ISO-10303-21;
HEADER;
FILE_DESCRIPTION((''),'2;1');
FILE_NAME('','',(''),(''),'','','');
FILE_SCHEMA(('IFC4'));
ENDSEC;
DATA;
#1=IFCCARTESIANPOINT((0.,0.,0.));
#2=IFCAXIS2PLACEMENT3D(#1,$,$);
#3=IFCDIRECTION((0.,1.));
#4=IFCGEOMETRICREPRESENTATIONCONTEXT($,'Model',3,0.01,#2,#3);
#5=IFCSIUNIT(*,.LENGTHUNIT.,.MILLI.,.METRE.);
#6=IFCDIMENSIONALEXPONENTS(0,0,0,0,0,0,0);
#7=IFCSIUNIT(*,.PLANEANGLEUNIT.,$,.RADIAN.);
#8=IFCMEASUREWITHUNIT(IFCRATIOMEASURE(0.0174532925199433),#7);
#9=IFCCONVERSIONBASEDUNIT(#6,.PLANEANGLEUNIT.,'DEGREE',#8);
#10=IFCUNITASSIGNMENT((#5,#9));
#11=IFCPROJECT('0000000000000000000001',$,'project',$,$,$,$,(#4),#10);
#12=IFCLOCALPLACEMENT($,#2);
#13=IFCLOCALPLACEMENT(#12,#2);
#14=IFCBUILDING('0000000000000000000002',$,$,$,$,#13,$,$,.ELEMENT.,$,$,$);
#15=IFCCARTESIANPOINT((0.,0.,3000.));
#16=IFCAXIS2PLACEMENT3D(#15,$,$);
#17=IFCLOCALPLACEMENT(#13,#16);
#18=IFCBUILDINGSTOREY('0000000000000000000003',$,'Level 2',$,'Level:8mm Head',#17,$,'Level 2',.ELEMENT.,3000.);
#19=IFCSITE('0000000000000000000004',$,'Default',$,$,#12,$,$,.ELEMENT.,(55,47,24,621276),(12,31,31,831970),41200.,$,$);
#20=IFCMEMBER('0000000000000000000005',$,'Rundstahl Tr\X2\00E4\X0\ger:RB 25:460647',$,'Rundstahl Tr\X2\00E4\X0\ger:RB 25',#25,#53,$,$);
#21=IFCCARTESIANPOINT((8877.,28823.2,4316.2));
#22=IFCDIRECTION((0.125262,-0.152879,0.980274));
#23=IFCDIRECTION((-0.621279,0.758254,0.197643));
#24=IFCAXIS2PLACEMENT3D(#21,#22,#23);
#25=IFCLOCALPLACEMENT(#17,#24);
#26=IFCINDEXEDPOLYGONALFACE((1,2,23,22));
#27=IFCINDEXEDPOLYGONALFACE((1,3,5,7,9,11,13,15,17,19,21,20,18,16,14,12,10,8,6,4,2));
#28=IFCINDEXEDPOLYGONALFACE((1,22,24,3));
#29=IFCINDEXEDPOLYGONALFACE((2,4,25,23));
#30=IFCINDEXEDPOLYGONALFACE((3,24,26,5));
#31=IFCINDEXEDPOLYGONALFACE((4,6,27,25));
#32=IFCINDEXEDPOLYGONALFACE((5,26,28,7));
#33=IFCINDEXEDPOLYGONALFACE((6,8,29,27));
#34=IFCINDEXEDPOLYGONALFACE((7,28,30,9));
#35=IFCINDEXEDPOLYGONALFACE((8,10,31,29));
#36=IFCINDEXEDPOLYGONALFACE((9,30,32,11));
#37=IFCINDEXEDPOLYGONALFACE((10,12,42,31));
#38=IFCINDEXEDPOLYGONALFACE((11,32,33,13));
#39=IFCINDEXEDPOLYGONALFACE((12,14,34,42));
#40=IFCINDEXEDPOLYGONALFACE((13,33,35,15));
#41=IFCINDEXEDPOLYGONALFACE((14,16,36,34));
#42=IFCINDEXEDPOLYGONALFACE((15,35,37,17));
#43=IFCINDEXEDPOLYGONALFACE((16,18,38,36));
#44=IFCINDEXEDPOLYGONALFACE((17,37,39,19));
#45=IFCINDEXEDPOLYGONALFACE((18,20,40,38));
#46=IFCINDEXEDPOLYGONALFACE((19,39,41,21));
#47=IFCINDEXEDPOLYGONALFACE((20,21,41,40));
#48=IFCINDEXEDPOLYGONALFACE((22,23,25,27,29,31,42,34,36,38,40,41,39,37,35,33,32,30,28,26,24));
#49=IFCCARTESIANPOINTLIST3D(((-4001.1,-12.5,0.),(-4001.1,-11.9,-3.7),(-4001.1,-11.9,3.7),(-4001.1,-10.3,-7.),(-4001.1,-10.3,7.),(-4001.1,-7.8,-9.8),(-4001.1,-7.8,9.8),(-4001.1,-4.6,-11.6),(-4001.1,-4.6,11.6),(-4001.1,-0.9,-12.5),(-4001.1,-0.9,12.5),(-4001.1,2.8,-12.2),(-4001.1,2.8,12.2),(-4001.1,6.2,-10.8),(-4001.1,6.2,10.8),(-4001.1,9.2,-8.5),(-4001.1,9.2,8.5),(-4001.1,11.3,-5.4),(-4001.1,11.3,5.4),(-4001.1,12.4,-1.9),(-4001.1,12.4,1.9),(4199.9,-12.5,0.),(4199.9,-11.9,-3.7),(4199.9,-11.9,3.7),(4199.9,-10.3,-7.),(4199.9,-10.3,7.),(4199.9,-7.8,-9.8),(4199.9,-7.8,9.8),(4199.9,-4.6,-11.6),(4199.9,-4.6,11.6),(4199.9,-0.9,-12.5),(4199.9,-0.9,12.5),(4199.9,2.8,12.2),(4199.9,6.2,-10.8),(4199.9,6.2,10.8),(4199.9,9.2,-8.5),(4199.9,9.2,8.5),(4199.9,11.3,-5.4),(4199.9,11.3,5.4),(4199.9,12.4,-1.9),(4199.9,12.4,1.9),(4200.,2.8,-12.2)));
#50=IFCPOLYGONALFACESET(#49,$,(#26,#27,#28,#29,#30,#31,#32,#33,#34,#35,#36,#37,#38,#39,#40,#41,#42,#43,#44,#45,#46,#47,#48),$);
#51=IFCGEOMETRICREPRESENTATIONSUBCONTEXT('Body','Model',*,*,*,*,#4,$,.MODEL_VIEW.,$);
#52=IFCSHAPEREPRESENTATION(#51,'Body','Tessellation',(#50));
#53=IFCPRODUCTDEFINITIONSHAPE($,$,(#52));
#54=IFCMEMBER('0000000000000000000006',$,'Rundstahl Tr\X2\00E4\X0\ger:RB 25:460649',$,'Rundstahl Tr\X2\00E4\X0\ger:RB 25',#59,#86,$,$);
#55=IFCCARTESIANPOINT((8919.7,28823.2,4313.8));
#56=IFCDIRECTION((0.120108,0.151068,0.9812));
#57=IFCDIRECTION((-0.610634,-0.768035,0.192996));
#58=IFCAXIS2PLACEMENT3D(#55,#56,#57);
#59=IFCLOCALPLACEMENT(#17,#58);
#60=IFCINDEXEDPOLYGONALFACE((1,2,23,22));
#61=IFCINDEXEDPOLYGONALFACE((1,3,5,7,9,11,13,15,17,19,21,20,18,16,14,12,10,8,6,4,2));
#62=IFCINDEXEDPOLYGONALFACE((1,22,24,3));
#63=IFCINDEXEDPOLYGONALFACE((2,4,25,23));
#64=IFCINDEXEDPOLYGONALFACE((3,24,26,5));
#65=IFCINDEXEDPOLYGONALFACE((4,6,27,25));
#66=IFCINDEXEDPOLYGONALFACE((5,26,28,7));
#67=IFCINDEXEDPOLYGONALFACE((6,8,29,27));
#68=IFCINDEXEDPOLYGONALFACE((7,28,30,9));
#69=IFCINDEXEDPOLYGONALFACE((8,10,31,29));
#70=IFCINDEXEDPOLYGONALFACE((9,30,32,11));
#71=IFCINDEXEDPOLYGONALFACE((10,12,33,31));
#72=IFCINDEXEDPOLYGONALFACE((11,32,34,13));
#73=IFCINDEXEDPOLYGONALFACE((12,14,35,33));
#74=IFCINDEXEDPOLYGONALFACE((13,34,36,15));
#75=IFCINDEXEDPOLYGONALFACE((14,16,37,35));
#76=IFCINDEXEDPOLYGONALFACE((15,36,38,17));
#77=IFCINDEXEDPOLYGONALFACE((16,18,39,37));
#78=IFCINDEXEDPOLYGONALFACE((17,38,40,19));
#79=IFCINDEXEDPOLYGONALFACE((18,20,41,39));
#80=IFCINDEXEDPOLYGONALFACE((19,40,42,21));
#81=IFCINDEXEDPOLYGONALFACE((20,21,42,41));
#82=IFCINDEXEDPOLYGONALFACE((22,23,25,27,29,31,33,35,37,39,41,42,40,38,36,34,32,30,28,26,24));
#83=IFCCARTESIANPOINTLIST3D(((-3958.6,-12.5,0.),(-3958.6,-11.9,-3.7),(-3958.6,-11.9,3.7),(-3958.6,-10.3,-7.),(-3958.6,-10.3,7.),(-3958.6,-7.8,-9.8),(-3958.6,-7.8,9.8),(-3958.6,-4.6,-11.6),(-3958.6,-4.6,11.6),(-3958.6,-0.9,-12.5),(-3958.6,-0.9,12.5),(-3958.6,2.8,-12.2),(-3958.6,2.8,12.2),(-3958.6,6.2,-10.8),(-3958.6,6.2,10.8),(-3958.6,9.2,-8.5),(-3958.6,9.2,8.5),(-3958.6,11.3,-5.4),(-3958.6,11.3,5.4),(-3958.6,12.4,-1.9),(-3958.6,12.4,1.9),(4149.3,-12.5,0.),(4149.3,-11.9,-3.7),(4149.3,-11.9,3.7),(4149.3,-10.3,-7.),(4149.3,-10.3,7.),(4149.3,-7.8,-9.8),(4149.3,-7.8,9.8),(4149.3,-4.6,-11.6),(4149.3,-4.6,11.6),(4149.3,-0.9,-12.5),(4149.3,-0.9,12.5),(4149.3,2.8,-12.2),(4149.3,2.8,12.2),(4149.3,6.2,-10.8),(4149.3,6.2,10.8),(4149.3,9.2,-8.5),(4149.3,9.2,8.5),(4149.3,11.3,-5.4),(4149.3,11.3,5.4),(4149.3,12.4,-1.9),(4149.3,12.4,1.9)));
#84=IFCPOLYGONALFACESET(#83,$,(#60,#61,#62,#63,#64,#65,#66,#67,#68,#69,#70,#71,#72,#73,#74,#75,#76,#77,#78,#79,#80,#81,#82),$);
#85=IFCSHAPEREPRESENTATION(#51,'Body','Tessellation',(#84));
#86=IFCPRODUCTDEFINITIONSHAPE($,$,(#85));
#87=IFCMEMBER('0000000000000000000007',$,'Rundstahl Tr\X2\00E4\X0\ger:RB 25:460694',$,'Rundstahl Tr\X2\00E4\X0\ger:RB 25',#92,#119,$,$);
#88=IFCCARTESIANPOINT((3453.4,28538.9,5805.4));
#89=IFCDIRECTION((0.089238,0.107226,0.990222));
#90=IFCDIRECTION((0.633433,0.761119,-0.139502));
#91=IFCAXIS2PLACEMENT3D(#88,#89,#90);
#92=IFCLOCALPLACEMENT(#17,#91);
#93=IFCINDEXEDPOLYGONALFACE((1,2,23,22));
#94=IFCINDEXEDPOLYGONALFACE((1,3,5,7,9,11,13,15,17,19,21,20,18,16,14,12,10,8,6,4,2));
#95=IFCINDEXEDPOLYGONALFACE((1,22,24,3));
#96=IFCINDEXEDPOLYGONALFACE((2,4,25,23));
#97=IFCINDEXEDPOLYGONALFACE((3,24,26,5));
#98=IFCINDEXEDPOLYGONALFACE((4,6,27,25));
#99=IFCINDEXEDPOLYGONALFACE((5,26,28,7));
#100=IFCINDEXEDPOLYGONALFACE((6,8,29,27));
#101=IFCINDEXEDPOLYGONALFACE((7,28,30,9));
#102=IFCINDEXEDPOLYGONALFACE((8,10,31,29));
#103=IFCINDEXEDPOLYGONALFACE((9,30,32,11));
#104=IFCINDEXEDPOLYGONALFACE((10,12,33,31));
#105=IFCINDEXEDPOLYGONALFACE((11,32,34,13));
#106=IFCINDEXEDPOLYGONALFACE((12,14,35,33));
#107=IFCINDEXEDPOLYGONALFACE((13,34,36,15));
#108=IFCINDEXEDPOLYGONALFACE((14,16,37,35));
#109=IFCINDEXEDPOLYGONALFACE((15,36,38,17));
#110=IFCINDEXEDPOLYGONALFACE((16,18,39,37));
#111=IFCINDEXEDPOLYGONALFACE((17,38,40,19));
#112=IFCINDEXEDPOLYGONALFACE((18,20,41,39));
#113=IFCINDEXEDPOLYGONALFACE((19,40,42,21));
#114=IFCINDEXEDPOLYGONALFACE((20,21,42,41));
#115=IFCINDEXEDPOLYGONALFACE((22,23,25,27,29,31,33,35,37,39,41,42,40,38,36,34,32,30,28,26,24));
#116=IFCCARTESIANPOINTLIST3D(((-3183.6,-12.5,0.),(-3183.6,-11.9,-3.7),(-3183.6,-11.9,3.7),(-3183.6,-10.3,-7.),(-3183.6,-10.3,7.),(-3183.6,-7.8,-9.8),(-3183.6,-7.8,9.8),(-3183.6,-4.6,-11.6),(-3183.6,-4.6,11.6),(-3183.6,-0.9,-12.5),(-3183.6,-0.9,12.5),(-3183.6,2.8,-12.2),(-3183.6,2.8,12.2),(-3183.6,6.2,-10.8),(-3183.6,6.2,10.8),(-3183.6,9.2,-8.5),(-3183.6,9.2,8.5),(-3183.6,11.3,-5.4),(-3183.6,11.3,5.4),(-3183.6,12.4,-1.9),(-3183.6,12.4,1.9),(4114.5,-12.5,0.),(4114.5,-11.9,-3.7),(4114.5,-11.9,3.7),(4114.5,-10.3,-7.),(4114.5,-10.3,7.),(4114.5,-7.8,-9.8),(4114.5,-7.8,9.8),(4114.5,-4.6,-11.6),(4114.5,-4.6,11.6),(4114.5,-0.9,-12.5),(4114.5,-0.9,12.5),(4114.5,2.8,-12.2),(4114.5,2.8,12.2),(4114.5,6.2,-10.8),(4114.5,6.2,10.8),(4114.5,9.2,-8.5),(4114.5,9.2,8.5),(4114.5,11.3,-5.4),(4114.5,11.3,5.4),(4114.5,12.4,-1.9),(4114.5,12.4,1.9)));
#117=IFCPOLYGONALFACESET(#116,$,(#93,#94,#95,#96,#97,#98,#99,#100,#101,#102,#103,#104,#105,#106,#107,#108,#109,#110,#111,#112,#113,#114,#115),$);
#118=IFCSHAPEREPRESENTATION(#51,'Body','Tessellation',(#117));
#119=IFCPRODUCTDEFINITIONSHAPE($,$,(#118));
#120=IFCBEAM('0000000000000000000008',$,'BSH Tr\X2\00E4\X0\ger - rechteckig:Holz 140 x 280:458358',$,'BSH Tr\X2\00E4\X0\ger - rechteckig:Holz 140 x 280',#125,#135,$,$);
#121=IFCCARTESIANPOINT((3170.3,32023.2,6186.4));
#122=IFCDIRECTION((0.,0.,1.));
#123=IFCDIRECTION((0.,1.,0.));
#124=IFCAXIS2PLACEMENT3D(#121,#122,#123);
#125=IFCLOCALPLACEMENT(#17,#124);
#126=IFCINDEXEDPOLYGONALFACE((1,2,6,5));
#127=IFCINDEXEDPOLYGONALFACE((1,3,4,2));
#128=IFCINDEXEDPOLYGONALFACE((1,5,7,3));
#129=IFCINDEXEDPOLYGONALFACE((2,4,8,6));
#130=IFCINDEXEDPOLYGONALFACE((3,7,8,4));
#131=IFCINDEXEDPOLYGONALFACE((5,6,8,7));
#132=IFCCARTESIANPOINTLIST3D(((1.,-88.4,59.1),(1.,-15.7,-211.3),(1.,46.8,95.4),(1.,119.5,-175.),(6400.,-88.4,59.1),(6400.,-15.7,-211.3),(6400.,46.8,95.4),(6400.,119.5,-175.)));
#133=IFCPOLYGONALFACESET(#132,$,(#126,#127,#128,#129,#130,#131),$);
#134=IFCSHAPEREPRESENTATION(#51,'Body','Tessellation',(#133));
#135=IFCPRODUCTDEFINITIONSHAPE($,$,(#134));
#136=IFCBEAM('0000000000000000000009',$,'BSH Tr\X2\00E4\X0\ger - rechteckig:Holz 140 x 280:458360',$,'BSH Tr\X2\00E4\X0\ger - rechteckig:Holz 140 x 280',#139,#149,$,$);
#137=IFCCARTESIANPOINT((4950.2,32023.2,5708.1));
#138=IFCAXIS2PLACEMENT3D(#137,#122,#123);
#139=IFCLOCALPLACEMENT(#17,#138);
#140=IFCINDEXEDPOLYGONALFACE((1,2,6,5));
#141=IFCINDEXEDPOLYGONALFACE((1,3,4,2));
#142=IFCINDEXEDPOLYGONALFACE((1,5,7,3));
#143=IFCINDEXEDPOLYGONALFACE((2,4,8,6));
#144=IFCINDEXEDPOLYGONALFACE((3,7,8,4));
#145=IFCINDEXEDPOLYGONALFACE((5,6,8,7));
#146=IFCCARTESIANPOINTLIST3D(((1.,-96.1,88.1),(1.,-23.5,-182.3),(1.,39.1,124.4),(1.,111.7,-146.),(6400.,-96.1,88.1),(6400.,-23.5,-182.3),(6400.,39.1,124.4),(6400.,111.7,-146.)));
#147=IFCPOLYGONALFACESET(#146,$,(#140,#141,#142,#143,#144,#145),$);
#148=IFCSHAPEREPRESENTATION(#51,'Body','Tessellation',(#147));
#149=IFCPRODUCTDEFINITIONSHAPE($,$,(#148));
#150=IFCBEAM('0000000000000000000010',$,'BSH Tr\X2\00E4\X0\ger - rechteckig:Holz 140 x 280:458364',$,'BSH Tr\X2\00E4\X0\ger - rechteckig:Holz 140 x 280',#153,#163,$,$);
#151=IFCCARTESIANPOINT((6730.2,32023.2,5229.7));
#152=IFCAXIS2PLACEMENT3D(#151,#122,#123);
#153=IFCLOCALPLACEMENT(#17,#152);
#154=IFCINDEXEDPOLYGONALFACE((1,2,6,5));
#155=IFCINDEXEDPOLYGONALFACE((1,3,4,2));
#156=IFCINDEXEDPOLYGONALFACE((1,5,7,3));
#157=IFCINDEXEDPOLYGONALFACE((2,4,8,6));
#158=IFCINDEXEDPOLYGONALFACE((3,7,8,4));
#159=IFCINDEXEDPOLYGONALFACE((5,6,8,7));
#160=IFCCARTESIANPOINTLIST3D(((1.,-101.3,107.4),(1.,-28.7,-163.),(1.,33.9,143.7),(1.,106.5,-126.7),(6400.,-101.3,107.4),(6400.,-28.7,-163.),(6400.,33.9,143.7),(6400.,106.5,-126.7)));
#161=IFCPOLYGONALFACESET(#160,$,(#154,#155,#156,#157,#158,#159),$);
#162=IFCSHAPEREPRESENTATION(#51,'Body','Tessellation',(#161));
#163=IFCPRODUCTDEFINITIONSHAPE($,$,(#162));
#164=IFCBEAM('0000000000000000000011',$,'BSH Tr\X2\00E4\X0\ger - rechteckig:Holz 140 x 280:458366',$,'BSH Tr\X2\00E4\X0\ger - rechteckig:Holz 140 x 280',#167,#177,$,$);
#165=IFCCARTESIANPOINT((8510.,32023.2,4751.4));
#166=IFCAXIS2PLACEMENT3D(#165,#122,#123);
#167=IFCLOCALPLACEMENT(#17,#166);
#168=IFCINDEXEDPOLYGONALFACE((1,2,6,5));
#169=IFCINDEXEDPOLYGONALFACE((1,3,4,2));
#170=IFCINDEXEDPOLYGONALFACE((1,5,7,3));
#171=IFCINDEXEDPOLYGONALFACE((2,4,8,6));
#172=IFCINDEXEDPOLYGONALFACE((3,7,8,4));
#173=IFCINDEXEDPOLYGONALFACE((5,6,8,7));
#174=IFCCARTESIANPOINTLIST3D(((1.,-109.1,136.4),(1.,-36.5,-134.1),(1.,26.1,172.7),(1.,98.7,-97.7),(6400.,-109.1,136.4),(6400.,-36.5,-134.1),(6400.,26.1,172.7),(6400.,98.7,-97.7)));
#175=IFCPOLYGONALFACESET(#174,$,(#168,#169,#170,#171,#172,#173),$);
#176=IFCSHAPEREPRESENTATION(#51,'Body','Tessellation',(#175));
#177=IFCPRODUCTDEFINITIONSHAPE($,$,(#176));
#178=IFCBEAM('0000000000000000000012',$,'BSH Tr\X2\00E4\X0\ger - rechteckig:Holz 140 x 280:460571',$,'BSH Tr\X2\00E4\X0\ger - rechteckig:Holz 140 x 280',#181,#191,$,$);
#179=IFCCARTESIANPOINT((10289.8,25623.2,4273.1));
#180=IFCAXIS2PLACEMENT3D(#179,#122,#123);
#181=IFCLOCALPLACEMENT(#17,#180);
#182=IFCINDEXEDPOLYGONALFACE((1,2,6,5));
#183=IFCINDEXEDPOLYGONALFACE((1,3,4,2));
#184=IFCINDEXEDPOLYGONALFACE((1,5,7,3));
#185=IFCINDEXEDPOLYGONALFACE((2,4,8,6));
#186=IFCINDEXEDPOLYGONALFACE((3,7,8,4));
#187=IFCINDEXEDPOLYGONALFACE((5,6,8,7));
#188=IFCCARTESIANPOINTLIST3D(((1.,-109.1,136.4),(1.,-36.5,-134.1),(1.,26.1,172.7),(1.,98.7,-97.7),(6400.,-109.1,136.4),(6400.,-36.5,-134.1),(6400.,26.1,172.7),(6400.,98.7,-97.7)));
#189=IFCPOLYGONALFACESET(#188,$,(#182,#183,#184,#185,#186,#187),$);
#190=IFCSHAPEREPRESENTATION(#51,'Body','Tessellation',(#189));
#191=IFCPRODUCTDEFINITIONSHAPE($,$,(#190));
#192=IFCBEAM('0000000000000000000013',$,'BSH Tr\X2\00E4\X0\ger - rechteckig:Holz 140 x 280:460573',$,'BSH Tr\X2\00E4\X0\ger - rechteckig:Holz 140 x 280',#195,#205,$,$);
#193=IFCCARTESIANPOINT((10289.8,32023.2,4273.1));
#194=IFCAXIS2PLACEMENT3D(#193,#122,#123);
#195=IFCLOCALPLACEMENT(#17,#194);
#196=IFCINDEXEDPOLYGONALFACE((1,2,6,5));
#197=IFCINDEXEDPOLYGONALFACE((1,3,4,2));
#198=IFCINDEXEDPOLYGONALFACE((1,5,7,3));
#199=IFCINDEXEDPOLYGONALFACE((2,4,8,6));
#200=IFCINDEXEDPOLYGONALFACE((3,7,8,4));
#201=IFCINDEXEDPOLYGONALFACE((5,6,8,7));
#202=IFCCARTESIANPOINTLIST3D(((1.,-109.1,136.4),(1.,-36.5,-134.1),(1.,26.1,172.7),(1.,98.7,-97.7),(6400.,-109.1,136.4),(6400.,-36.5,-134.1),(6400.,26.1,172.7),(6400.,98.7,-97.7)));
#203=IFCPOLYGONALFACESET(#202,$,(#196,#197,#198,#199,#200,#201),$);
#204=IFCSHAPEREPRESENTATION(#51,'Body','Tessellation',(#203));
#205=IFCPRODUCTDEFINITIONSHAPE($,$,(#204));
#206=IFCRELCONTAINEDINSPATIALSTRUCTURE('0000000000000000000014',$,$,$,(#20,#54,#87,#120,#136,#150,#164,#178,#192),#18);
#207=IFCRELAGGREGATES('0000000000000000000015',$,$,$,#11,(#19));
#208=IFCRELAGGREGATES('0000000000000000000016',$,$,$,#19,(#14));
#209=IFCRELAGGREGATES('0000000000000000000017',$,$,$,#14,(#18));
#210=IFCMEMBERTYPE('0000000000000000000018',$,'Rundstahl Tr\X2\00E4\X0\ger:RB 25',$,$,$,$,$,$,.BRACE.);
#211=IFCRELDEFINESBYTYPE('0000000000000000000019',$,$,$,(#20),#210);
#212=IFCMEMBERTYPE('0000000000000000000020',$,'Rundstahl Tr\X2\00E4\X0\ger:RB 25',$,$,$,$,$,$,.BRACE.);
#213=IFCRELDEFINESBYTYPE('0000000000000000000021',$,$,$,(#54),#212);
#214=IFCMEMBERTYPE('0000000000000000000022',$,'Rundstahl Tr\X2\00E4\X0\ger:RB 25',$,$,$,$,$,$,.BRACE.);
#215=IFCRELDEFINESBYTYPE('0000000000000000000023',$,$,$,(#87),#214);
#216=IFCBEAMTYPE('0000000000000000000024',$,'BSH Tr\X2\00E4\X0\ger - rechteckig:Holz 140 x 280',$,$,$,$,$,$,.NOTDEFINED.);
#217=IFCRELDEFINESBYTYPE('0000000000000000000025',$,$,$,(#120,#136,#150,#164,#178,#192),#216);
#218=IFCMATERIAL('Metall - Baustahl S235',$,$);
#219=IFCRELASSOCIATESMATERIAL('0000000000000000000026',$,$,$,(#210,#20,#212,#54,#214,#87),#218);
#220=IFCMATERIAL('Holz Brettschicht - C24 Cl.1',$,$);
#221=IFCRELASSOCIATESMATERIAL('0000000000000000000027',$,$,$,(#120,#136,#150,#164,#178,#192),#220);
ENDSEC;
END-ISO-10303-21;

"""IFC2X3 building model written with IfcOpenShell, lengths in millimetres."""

from ifc_helpers import new_model, entity, si_unit, converted_unit, direction, frame, frame_2d, origin, place, context, subcontext, project, spatial, rectangle, circle, extrude, source, transform, mapped, material, type_object, type_shapes, element, save


model = new_model("IFC2X3")

# Units and contexts
model_context = context("Model", 3, precision=0.01, world=origin(), true_north=direction((0.0, 1.0)))
body_context = subcontext(model_context, "Body", "Model", "MODEL_VIEW")
ifc_project = project(units=[si_unit("LENGTHUNIT", "METRE", prefix="MILLI"), converted_unit("PLANEANGLEUNIT", "DEGREE", entity("IfcRatioMeasure", 0.0174532925199433), si_unit("PLANEANGLEUNIT", "RADIAN"), dimensions=[0, 0, 0, 0, 0, 0, 0])], contexts=[model_context])

# Site, building, storey
site_placement = place(None, origin())
site = spatial("IfcSite", under=ifc_project, at=site_placement, Name="Default", CompositionType="ELEMENT", RefLatitude=(55, 47, 24, 621276), RefLongitude=(12, 31, 31, 831970), RefElevation=41200.0)
building_placement = place(site_placement, origin())
building = spatial("IfcBuilding", under=site, at=building_placement, CompositionType="ELEMENT")
storey_placement = place(building_placement, frame((0.0, 0.0, 3000.0)))
storey = spatial("IfcBuildingStorey", under=building, at=storey_placement, Name="Level 2", ObjectType="Level:8mm Head", LongName="Level 2", CompositionType="ELEMENT", Elevation=3000.0)

# Members
ifc_material_1 = material(Name="Metall - Baustahl S235")
member_type_1 = type_object("IfcMemberType", Name="Rundstahl Träger:RB 25", PredefinedType="BRACE", material=ifc_material_1)
shared_shape_1 = source(origin(), body_context, "Body", "SweptSolid", [
    extrude(circle(Radius=12.5, at=frame_2d((0.0, 0.0), x_axis=(1.0, 0.0))), frame((-4001.2, 0.0, 0.0), z_axis=(1.0, 0.0, 0.0), x_axis=(0.0, -1.0, 0.0)), (0.0, 0.0, 1.0), 8201.1),
])
type_shapes(member_type_1, [shared_shape_1])
member_1_placement = place(storey_placement, frame((8877.0, 28823.2, 4316.2), z_axis=(0.125262, -0.152879, 0.980274), x_axis=(-0.621279, 0.758254, 0.197643)))
element("IfcMember", 1, at=member_1_placement, inside=storey, type_object=member_type_1, material=ifc_material_1, Name="Rundstahl Träger:RB 25:460647", ObjectType="Rundstahl Träger:RB 25", context=body_context, shape_type="MappedRepresentation", body=[
    mapped(shared_shape_1, transform((0.0, 0.0, 0.0), scale=1.0)),
])
member_type_2 = type_object("IfcMemberType", Name="Rundstahl Träger:RB 25", PredefinedType="BRACE", material=ifc_material_1)
shared_shape_2 = source(origin(), body_context, "Body", "SweptSolid", [
    extrude(circle(Radius=12.5, at=frame_2d((0.0, 0.0), x_axis=(1.0, 0.0))), frame((-3958.6, 0.0, 0.0), z_axis=(1.0, 0.0, 0.0), x_axis=(0.0, -1.0, 0.0)), (0.0, 0.0, 1.0), 8107.9),
])
type_shapes(member_type_2, [shared_shape_2])
member_2_placement = place(storey_placement, frame((8919.7, 28823.2, 4313.8), z_axis=(0.120108, 0.151068, 0.9812), x_axis=(-0.610634, -0.768035, 0.192996)))
element("IfcMember", 2, at=member_2_placement, inside=storey, type_object=member_type_2, material=ifc_material_1, Name="Rundstahl Träger:RB 25:460649", ObjectType="Rundstahl Träger:RB 25", context=body_context, shape_type="MappedRepresentation", body=[
    mapped(shared_shape_2, transform((0.0, 0.0, 0.0), scale=1.0)),
])
member_type_3 = type_object("IfcMemberType", Name="Rundstahl Träger:RB 25", PredefinedType="BRACE", material=ifc_material_1)
shared_shape_3 = source(origin(), body_context, "Body", "SweptSolid", [
    extrude(circle(Radius=12.5, at=frame_2d((0.0, 0.0), x_axis=(1.0, 0.0))), frame((-3183.7, 0.0, 0.0), z_axis=(1.0, 0.0, 0.0), x_axis=(0.0, -1.0, 0.0)), (0.0, 0.0, 1.0), 7298.2),
])
type_shapes(member_type_3, [shared_shape_3])
member_3_placement = place(storey_placement, frame((3453.4, 28538.9, 5805.4), z_axis=(0.089238, 0.107226, 0.990222), x_axis=(0.633433, 0.761119, -0.139502)))
element("IfcMember", 3, at=member_3_placement, inside=storey, type_object=member_type_3, material=ifc_material_1, Name="Rundstahl Träger:RB 25:460694", ObjectType="Rundstahl Träger:RB 25", context=body_context, shape_type="MappedRepresentation", body=[
    mapped(shared_shape_3, transform((0.0, 0.0, 0.0), scale=1.0)),
])

# Beams
ifc_material_2 = material(Name="Holz Brettschicht - C24 Cl.1")
beam_type_1 = type_object("IfcBeamType", Name="BSH Träger - rechteckig:Holz 140 x 280", PredefinedType="NOTDEFINED")
beam_1_placement = place(storey_placement, frame((3170.3, 32023.2, 6186.4), z_axis=(0.0, 0.0, 1.0), x_axis=(0.0, 1.0, 0.0)))
element("IfcBeam", 4, at=beam_1_placement, inside=storey, type_object=beam_type_1, material=ifc_material_2, Name="BSH Träger - rechteckig:Holz 140 x 280:458358", ObjectType="BSH Träger - rechteckig:Holz 140 x 280", context=body_context, shape_type="SweptSolid", body=[
    extrude(rectangle(XDim=280.0, YDim=140.0, at=frame_2d((0.0, 0.0), x_axis=(1.0, 0.0))), frame((1.0, 15.6, -57.9), z_axis=(1.0, 0.0, 0.0), x_axis=(0.0, -0.259528, 0.965735)), (0.0, 0.0, 1.0), 6399.0),
])
beam_2_placement = place(storey_placement, frame((4950.2, 32023.2, 5708.1), z_axis=(0.0, 0.0, 1.0), x_axis=(0.0, 1.0, 0.0)))
element("IfcBeam", 5, at=beam_2_placement, inside=storey, type_object=beam_type_1, material=ifc_material_2, Name="BSH Träger - rechteckig:Holz 140 x 280:458360", ObjectType="BSH Träger - rechteckig:Holz 140 x 280", context=body_context, shape_type="SweptSolid", body=[
    extrude(rectangle(XDim=280.0, YDim=140.0, at=frame_2d((0.0, 0.0), x_axis=(1.0, 0.0))), frame((1.0, 7.8, -29.0), z_axis=(1.0, 0.0, 0.0), x_axis=(0.0, -0.259528, 0.965735)), (0.0, 0.0, 1.0), 6399.0),
])
beam_3_placement = place(storey_placement, frame((6730.2, 32023.2, 5229.7), z_axis=(0.0, 0.0, 1.0), x_axis=(0.0, 1.0, 0.0)))
element("IfcBeam", 6, at=beam_3_placement, inside=storey, type_object=beam_type_1, material=ifc_material_2, Name="BSH Träger - rechteckig:Holz 140 x 280:458364", ObjectType="BSH Träger - rechteckig:Holz 140 x 280", context=body_context, shape_type="SweptSolid", body=[
    extrude(rectangle(XDim=280.0, YDim=140.0, at=frame_2d((0.0, 0.0), x_axis=(1.0, 0.0))), frame((1.0, 2.6, -9.7), z_axis=(1.0, 0.0, 0.0), x_axis=(0.0, -0.259528, 0.965735)), (0.0, 0.0, 1.0), 6399.0),
])
beam_4_placement = place(storey_placement, frame((8510.0, 32023.2, 4751.4), z_axis=(0.0, 0.0, 1.0), x_axis=(0.0, 1.0, 0.0)))
element("IfcBeam", 7, at=beam_4_placement, inside=storey, type_object=beam_type_1, material=ifc_material_2, Name="BSH Träger - rechteckig:Holz 140 x 280:458366", ObjectType="BSH Träger - rechteckig:Holz 140 x 280", context=body_context, shape_type="SweptSolid", body=[
    extrude(rectangle(XDim=280.0, YDim=140.0, at=frame_2d((0.0, 0.0), x_axis=(1.0, 0.0))), frame((1.0, -5.2, 19.3), z_axis=(1.0, 0.0, 0.0), x_axis=(0.0, -0.259528, 0.965735)), (0.0, 0.0, 1.0), 6399.0),
])
beam_5_placement = place(storey_placement, frame((10289.8, 25623.2, 4273.1), z_axis=(0.0, 0.0, 1.0), x_axis=(0.0, 1.0, 0.0)))
element("IfcBeam", 8, at=beam_5_placement, inside=storey, type_object=beam_type_1, material=ifc_material_2, Name="BSH Träger - rechteckig:Holz 140 x 280:460571", ObjectType="BSH Träger - rechteckig:Holz 140 x 280", context=body_context, shape_type="SweptSolid", body=[
    extrude(rectangle(XDim=280.0, YDim=140.0, at=frame_2d((0.0, 0.0), x_axis=(1.0, 0.0))), frame((1.0, -5.2, 19.3), z_axis=(1.0, 0.0, 0.0), x_axis=(0.0, -0.259528, 0.965735)), (0.0, 0.0, 1.0), 6399.0),
])
beam_6_placement = place(storey_placement, frame((10289.8, 32023.2, 4273.1), z_axis=(0.0, 0.0, 1.0), x_axis=(0.0, 1.0, 0.0)))
element("IfcBeam", 9, at=beam_6_placement, inside=storey, type_object=beam_type_1, material=ifc_material_2, Name="BSH Träger - rechteckig:Holz 140 x 280:460573", ObjectType="BSH Träger - rechteckig:Holz 140 x 280", context=body_context, shape_type="SweptSolid", body=[
    extrude(rectangle(XDim=280.0, YDim=140.0, at=frame_2d((0.0, 0.0), x_axis=(1.0, 0.0))), frame((1.0, -5.2, 19.3), z_axis=(1.0, 0.0, 0.0), x_axis=(0.0, -0.259528, 0.965735)), (0.0, 0.0, 1.0), 6399.0),
])

save(model, "model.ifc")
